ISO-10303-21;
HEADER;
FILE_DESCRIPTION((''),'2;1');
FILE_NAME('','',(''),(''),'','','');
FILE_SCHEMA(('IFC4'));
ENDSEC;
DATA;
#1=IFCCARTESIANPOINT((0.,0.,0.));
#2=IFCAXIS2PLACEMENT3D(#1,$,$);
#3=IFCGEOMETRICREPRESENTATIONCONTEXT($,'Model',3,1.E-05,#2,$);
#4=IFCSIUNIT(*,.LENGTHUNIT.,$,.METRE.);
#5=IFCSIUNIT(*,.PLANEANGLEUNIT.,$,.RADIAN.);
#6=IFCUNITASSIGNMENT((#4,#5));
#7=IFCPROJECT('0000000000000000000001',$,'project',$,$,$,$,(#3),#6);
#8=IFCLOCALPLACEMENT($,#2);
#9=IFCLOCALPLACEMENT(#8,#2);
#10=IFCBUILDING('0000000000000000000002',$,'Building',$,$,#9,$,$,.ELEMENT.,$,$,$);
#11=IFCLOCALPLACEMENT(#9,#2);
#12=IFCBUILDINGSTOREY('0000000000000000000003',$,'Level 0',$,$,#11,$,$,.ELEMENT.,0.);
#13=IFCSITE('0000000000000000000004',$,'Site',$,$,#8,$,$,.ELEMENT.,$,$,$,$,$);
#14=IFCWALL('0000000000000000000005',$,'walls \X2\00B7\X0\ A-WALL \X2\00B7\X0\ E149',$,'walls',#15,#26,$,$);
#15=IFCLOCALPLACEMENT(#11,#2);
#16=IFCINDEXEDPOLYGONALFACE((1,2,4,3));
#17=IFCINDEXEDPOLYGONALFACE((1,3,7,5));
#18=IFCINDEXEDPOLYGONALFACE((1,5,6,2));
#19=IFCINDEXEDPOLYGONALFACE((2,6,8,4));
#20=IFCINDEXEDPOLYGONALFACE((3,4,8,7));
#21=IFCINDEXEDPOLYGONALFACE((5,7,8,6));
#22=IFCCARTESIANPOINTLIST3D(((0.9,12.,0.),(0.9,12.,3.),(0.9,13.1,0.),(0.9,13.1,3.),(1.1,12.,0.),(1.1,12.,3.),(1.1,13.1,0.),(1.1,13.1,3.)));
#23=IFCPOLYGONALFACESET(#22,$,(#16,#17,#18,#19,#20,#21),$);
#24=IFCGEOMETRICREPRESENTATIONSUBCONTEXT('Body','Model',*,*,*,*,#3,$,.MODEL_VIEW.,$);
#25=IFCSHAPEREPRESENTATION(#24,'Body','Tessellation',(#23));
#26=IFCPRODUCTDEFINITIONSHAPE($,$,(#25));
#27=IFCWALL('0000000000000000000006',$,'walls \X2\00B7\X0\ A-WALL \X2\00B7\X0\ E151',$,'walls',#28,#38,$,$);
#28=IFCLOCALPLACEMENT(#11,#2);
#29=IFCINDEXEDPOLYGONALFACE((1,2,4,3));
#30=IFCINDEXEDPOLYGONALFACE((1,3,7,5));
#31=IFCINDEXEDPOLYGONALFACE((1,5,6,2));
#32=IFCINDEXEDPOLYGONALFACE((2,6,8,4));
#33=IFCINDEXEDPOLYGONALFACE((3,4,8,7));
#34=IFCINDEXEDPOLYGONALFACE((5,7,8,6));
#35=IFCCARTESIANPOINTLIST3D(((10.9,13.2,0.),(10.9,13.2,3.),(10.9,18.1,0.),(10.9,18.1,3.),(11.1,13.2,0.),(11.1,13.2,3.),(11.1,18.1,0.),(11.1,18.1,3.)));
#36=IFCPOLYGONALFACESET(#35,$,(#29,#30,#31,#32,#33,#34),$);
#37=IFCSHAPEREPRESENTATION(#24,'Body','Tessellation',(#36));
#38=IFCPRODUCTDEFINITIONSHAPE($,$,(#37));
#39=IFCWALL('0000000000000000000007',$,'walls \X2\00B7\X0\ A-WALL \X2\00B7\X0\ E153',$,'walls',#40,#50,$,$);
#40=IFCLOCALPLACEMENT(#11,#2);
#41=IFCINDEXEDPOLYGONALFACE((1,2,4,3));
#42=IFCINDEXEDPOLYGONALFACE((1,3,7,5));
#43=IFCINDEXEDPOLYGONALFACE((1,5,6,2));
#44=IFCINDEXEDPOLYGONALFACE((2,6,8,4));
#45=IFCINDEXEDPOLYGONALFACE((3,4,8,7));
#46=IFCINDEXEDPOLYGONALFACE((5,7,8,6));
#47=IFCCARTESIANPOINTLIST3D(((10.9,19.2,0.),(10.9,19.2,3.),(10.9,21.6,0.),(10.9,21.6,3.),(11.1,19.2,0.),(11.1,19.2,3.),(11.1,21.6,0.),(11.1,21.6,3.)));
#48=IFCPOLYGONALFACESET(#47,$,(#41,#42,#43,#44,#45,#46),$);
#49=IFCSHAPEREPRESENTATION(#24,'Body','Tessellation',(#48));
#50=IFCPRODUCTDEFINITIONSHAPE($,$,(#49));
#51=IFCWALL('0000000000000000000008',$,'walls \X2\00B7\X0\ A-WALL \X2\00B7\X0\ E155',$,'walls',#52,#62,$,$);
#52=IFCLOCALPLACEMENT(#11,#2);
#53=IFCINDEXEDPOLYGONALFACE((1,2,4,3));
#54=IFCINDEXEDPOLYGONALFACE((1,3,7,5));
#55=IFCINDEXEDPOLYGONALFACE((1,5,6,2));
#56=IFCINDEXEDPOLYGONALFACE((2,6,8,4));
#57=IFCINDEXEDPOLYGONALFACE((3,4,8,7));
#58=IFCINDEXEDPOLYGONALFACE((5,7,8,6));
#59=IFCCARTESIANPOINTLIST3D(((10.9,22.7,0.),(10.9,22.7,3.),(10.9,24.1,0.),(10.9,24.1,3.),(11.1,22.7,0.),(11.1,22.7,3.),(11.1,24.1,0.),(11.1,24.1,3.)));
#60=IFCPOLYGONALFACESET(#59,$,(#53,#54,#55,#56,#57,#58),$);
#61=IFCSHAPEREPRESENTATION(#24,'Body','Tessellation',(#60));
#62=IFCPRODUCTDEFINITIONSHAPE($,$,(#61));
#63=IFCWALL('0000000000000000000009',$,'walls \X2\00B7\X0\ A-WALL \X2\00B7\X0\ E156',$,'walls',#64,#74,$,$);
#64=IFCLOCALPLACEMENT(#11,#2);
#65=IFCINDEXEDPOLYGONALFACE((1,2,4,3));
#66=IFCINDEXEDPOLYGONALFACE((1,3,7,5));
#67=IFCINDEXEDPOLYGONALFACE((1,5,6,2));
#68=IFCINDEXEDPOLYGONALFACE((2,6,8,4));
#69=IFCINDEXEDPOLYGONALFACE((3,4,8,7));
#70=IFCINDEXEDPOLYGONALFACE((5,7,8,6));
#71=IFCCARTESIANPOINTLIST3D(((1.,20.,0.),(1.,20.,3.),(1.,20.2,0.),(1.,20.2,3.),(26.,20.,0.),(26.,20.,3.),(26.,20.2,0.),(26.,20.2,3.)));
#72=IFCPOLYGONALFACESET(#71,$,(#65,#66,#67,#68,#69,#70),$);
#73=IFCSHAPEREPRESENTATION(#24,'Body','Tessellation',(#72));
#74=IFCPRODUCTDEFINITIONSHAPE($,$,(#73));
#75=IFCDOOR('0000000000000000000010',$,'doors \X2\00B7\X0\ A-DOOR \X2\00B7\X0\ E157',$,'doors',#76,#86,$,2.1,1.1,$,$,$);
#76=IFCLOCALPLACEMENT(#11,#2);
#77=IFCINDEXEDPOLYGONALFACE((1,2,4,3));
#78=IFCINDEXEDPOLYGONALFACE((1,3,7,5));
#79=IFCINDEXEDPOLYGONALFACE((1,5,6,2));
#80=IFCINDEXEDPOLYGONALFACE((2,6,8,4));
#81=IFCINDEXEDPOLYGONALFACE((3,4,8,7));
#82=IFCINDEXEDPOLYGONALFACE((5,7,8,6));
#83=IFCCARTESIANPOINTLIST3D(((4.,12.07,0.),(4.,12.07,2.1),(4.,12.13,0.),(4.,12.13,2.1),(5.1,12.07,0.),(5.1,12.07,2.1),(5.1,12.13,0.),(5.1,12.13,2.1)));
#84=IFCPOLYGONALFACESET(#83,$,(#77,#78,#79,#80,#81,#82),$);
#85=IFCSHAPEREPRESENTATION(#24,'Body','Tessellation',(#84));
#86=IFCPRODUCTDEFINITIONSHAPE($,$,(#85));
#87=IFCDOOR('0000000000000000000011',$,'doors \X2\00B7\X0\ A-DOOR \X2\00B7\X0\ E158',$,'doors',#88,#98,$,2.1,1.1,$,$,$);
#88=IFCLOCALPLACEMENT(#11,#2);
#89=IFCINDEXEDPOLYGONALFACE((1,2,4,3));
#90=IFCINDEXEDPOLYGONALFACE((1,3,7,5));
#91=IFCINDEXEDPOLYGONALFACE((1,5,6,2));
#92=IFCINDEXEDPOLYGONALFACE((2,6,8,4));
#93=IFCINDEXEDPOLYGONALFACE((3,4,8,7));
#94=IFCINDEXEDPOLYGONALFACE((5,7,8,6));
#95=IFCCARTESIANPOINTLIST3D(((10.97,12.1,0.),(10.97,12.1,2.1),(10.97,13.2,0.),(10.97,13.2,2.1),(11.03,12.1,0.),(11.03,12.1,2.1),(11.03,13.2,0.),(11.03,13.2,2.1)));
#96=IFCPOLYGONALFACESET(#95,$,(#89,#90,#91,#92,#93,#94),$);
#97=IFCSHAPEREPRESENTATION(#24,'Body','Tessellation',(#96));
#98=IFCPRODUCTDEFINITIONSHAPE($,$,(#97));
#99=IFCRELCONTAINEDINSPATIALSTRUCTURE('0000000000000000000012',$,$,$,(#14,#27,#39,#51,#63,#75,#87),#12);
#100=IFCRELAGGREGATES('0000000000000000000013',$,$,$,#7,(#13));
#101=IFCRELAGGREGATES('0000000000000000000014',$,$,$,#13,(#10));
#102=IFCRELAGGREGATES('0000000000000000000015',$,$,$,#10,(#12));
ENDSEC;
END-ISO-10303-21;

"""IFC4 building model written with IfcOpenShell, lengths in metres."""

from ifc_helpers import new_model, si_unit, origin, place, context, subcontext, project, spatial, polyline, outline, extrude, element, save


model = new_model("IFC4")

# Units and contexts
model_context = context("Model", 3, precision=1e-05, world=origin())
body_context = subcontext(model_context, "Body", "Model", "MODEL_VIEW")
ifc_project = project(units=[si_unit("LENGTHUNIT", "METRE"), si_unit("PLANEANGLEUNIT", "RADIAN")], contexts=[model_context])

# Site, building, storey
site_placement = place(None, origin())
site = spatial("IfcSite", under=ifc_project, at=site_placement, Name="Site", CompositionType="ELEMENT")
building_placement = place(site_placement, origin())
building = spatial("IfcBuilding", under=site, at=building_placement, Name="Building", CompositionType="ELEMENT")
storey_placement = place(building_placement, origin())
storey = spatial("IfcBuildingStorey", under=building, at=storey_placement, Name="Level 0", CompositionType="ELEMENT", Elevation=0.0)

# Walls
wall_1_placement = place(storey_placement, origin())
element("IfcWall", 1, at=wall_1_placement, inside=storey, Name="walls · A-WALL · E149", ObjectType="walls", context=body_context, shape_type="SweptSolid", body=[
    extrude(outline(polyline([(0.9, 13.1), (0.9, 12.0), (1.1, 12.0), (1.1, 13.1), (0.9, 13.1)])), origin(), (0.0, 0.0, 1.0), 3.0),
])
wall_2_placement = place(storey_placement, origin())
element("IfcWall", 2, at=wall_2_placement, inside=storey, Name="walls · A-WALL · E151", ObjectType="walls", context=body_context, shape_type="SweptSolid", body=[
    extrude(outline(polyline([(11.1, 13.2), (11.1, 18.1), (10.9, 18.1), (10.9, 13.2), (11.1, 13.2)])), origin(), (0.0, 0.0, 1.0), 3.0),
])
wall_3_placement = place(storey_placement, origin())
element("IfcWall", 3, at=wall_3_placement, inside=storey, Name="walls · A-WALL · E153", ObjectType="walls", context=body_context, shape_type="SweptSolid", body=[
    extrude(outline(polyline([(11.1, 19.2), (11.1, 21.6), (10.9, 21.6), (10.9, 19.2), (11.1, 19.2)])), origin(), (0.0, 0.0, 1.0), 3.0),
])
wall_4_placement = place(storey_placement, origin())
element("IfcWall", 4, at=wall_4_placement, inside=storey, Name="walls · A-WALL · E155", ObjectType="walls", context=body_context, shape_type="SweptSolid", body=[
    extrude(outline(polyline([(11.1, 22.7), (11.1, 24.1), (10.9, 24.1), (10.9, 22.7), (11.1, 22.7)])), origin(), (0.0, 0.0, 1.0), 3.0),
])
wall_5_placement = place(storey_placement, origin())
element("IfcWall", 5, at=wall_5_placement, inside=storey, Name="walls · A-WALL · E156", ObjectType="walls", context=body_context, shape_type="SweptSolid", body=[
    extrude(outline(polyline([(1.0, 20.0), (26.0, 20.0), (26.0, 20.2), (1.0, 20.2), (1.0, 20.0)])), origin(), (0.0, 0.0, 1.0), 3.0),
])

# Doors
door_1_placement = place(storey_placement, origin())
element("IfcDoor", 6, at=door_1_placement, inside=storey, Name="doors · A-DOOR · E157", ObjectType="doors", OverallHeight=2.1, OverallWidth=1.1, context=body_context, shape_type="SweptSolid", body=[
    extrude(outline(polyline([(4.0, 12.07), (5.1, 12.07), (5.1, 12.13), (4.0, 12.13), (4.0, 12.07)])), origin(), (0.0, 0.0, 1.0), 2.1),
])
door_2_placement = place(storey_placement, origin())
element("IfcDoor", 7, at=door_2_placement, inside=storey, Name="doors · A-DOOR · E158", ObjectType="doors", OverallHeight=2.1, OverallWidth=1.1, context=body_context, shape_type="SweptSolid", body=[
    extrude(outline(polyline([(11.03, 12.1), (11.03, 13.2), (10.97, 13.2), (10.97, 12.1), (11.03, 12.1)])), origin(), (0.0, 0.0, 1.0), 2.1),
])

save(model, "model.ifc")
